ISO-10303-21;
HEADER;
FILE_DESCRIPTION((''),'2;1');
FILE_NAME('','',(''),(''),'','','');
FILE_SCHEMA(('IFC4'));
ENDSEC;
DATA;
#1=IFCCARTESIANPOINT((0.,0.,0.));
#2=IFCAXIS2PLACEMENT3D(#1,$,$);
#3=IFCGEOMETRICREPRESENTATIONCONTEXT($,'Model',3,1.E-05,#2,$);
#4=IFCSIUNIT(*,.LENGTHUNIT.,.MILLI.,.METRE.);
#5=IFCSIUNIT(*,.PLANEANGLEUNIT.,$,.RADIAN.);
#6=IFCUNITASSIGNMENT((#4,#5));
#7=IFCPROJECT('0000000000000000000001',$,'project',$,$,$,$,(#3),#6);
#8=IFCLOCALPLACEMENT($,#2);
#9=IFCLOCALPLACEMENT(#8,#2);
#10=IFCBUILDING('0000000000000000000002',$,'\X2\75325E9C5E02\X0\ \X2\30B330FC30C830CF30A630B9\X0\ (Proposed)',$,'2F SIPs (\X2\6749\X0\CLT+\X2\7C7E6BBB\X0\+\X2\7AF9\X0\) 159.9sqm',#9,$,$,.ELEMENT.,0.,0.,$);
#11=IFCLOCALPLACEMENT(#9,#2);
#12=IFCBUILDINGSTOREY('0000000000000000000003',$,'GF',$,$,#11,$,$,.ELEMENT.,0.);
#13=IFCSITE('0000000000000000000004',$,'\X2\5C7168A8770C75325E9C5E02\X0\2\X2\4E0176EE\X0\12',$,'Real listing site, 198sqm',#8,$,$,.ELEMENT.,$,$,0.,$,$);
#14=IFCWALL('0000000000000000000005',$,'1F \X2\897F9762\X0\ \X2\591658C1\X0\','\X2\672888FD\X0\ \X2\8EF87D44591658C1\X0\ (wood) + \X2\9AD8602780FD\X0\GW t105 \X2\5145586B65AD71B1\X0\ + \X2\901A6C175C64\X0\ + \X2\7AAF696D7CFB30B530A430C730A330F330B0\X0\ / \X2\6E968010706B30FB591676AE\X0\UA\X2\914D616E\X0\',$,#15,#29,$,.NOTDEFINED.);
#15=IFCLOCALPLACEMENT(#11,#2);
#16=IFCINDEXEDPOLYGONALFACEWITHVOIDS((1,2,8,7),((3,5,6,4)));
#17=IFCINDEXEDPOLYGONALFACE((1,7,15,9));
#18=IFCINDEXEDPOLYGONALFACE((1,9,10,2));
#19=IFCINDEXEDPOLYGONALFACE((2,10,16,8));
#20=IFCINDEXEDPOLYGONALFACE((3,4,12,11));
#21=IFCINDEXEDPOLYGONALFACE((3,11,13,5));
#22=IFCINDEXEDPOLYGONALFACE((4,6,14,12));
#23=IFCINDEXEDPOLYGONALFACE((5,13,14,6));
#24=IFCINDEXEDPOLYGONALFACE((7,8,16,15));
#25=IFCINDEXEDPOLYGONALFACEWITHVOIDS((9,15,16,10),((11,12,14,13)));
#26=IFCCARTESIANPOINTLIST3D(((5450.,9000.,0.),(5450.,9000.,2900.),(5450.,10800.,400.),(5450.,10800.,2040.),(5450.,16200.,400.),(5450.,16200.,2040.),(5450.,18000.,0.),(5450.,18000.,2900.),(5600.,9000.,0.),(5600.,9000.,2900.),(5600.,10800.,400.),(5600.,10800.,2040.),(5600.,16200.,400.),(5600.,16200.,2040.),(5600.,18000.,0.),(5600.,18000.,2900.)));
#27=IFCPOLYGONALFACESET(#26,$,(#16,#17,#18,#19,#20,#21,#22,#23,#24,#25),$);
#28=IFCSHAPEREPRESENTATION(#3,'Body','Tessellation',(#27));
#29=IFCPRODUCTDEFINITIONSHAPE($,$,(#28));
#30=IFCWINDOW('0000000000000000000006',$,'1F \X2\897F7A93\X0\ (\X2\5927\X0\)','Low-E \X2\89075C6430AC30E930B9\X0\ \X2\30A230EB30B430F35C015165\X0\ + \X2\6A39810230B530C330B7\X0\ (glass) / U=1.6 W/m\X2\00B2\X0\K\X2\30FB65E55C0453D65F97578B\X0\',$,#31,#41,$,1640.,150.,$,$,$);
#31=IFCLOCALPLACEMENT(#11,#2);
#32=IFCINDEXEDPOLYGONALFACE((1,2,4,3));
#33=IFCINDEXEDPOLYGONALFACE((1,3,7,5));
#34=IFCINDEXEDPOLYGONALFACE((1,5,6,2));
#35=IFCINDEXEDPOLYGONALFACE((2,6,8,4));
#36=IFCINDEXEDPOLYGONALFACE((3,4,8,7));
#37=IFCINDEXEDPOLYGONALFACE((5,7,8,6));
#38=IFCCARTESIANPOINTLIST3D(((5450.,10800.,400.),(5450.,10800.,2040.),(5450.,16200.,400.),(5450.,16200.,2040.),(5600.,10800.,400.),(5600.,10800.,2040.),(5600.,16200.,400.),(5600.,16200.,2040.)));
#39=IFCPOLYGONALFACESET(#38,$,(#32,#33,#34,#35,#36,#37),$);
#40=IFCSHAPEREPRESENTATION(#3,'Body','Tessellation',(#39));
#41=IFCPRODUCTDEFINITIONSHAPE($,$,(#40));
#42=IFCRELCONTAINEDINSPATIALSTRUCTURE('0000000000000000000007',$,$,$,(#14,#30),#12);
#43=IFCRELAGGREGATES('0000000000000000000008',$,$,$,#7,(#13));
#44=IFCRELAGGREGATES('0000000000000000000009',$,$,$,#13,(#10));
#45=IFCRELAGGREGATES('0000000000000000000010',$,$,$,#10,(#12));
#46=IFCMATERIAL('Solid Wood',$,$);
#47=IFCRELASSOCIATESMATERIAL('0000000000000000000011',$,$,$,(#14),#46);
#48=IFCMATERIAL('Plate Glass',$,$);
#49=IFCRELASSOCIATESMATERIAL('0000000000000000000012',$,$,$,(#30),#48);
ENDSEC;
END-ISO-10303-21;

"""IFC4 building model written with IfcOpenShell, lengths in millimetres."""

from ifc_helpers import new_model, si_unit, frame, frame_2d, origin, place, context, project, spatial, rectangle, extrude, material, element, fill, save


model = new_model("IFC4")

# Units and contexts
model_context = context("Model", 3, precision=1e-05, world=origin())
ifc_project = project(units=[si_unit("LENGTHUNIT", "METRE", prefix="MILLI"), si_unit("PLANEANGLEUNIT", "RADIAN")], contexts=[model_context])

# Site, building, storey
site_placement = place(None, origin())
site = spatial("IfcSite", under=ifc_project, at=site_placement, Name="山梨県甲府市2丁目12", ObjectType="Real listing site, 198sqm", CompositionType="ELEMENT", RefElevation=0.0)
building_placement = place(site_placement, origin())
building = spatial("IfcBuilding", under=site, at=building_placement, Name="甲府市 コートハウス (Proposed)", ObjectType="2F SIPs (杉CLT+籾殻+竹) 159.9sqm", CompositionType="ELEMENT", ElevationOfRefHeight=0.0, ElevationOfTerrain=0.0)
storey_placement = place(building_placement, origin())
storey = spatial("IfcBuildingStorey", under=building, at=storey_placement, Name="GF", CompositionType="ELEMENT", Elevation=0.0)

# Shared definitions
ifc_material_1 = material(Name="Solid Wood")

# Shared definitions
ifc_material_2 = material(Name="Plate Glass")

# Wall, opening, window
wall_1_placement = place(storey_placement, frame((2725.0, 4500.0, 0.0)))
wall_1 = element("IfcWall", 1, at=wall_1_placement, inside=storey, material=ifc_material_1, Name="1F 西面 外壁", Description="木製 軸組外壁 (wood) + 高性能GW t105 充填断熱 + 通気層 + 窯業系サイディング / 準耐火・外皮UA配慮", PredefinedType="NOTDEFINED", context=model_context, shape_type="SweptSolid", body=[
    extrude(rectangle(XDim=150.0, YDim=9000.0, at=frame_2d((75.0, 4500.0))), frame((2725.0, 4500.0, 0.0)), (0.0, 0.0, 1.0), 2900.0),
])
opening_1_placement = place(storey_placement, frame((2725.0, 5400.0, 200.0)))
opening_1 = element("IfcOpeningElement", 2, at=opening_1_placement, cuts=wall_1, PredefinedType="NOTDEFINED", context=model_context, shape_type="SweptSolid", body=[
    extrude(rectangle(XDim=150.0, YDim=5400.0, at=frame_2d((75.0, 2700.0))), frame((2725.0, 5400.0, 200.0)), (0.0, 0.0, 1.0), 1640.0),
])
window_1_placement = place(storey_placement, frame((2725.0, 5400.0, 200.0)))
window_1 = element("IfcWindow", 3, at=window_1_placement, inside=storey, material=ifc_material_2, Name="1F 西窓 (大)", Description="Low-E 複層ガラス アルゴン封入 + 樹脂サッシ (glass) / U=1.6 W/m²K・日射取得型", OverallHeight=1640.0, OverallWidth=150.0, context=model_context, shape_type="SweptSolid", body=[
    extrude(rectangle(XDim=150.0, YDim=5400.0, at=frame_2d((75.0, 2700.0))), frame((2725.0, 5400.0, 200.0)), (0.0, 0.0, 1.0), 1640.0),
])
fill(opening_1, window_1)

save(model, "model.ifc")
